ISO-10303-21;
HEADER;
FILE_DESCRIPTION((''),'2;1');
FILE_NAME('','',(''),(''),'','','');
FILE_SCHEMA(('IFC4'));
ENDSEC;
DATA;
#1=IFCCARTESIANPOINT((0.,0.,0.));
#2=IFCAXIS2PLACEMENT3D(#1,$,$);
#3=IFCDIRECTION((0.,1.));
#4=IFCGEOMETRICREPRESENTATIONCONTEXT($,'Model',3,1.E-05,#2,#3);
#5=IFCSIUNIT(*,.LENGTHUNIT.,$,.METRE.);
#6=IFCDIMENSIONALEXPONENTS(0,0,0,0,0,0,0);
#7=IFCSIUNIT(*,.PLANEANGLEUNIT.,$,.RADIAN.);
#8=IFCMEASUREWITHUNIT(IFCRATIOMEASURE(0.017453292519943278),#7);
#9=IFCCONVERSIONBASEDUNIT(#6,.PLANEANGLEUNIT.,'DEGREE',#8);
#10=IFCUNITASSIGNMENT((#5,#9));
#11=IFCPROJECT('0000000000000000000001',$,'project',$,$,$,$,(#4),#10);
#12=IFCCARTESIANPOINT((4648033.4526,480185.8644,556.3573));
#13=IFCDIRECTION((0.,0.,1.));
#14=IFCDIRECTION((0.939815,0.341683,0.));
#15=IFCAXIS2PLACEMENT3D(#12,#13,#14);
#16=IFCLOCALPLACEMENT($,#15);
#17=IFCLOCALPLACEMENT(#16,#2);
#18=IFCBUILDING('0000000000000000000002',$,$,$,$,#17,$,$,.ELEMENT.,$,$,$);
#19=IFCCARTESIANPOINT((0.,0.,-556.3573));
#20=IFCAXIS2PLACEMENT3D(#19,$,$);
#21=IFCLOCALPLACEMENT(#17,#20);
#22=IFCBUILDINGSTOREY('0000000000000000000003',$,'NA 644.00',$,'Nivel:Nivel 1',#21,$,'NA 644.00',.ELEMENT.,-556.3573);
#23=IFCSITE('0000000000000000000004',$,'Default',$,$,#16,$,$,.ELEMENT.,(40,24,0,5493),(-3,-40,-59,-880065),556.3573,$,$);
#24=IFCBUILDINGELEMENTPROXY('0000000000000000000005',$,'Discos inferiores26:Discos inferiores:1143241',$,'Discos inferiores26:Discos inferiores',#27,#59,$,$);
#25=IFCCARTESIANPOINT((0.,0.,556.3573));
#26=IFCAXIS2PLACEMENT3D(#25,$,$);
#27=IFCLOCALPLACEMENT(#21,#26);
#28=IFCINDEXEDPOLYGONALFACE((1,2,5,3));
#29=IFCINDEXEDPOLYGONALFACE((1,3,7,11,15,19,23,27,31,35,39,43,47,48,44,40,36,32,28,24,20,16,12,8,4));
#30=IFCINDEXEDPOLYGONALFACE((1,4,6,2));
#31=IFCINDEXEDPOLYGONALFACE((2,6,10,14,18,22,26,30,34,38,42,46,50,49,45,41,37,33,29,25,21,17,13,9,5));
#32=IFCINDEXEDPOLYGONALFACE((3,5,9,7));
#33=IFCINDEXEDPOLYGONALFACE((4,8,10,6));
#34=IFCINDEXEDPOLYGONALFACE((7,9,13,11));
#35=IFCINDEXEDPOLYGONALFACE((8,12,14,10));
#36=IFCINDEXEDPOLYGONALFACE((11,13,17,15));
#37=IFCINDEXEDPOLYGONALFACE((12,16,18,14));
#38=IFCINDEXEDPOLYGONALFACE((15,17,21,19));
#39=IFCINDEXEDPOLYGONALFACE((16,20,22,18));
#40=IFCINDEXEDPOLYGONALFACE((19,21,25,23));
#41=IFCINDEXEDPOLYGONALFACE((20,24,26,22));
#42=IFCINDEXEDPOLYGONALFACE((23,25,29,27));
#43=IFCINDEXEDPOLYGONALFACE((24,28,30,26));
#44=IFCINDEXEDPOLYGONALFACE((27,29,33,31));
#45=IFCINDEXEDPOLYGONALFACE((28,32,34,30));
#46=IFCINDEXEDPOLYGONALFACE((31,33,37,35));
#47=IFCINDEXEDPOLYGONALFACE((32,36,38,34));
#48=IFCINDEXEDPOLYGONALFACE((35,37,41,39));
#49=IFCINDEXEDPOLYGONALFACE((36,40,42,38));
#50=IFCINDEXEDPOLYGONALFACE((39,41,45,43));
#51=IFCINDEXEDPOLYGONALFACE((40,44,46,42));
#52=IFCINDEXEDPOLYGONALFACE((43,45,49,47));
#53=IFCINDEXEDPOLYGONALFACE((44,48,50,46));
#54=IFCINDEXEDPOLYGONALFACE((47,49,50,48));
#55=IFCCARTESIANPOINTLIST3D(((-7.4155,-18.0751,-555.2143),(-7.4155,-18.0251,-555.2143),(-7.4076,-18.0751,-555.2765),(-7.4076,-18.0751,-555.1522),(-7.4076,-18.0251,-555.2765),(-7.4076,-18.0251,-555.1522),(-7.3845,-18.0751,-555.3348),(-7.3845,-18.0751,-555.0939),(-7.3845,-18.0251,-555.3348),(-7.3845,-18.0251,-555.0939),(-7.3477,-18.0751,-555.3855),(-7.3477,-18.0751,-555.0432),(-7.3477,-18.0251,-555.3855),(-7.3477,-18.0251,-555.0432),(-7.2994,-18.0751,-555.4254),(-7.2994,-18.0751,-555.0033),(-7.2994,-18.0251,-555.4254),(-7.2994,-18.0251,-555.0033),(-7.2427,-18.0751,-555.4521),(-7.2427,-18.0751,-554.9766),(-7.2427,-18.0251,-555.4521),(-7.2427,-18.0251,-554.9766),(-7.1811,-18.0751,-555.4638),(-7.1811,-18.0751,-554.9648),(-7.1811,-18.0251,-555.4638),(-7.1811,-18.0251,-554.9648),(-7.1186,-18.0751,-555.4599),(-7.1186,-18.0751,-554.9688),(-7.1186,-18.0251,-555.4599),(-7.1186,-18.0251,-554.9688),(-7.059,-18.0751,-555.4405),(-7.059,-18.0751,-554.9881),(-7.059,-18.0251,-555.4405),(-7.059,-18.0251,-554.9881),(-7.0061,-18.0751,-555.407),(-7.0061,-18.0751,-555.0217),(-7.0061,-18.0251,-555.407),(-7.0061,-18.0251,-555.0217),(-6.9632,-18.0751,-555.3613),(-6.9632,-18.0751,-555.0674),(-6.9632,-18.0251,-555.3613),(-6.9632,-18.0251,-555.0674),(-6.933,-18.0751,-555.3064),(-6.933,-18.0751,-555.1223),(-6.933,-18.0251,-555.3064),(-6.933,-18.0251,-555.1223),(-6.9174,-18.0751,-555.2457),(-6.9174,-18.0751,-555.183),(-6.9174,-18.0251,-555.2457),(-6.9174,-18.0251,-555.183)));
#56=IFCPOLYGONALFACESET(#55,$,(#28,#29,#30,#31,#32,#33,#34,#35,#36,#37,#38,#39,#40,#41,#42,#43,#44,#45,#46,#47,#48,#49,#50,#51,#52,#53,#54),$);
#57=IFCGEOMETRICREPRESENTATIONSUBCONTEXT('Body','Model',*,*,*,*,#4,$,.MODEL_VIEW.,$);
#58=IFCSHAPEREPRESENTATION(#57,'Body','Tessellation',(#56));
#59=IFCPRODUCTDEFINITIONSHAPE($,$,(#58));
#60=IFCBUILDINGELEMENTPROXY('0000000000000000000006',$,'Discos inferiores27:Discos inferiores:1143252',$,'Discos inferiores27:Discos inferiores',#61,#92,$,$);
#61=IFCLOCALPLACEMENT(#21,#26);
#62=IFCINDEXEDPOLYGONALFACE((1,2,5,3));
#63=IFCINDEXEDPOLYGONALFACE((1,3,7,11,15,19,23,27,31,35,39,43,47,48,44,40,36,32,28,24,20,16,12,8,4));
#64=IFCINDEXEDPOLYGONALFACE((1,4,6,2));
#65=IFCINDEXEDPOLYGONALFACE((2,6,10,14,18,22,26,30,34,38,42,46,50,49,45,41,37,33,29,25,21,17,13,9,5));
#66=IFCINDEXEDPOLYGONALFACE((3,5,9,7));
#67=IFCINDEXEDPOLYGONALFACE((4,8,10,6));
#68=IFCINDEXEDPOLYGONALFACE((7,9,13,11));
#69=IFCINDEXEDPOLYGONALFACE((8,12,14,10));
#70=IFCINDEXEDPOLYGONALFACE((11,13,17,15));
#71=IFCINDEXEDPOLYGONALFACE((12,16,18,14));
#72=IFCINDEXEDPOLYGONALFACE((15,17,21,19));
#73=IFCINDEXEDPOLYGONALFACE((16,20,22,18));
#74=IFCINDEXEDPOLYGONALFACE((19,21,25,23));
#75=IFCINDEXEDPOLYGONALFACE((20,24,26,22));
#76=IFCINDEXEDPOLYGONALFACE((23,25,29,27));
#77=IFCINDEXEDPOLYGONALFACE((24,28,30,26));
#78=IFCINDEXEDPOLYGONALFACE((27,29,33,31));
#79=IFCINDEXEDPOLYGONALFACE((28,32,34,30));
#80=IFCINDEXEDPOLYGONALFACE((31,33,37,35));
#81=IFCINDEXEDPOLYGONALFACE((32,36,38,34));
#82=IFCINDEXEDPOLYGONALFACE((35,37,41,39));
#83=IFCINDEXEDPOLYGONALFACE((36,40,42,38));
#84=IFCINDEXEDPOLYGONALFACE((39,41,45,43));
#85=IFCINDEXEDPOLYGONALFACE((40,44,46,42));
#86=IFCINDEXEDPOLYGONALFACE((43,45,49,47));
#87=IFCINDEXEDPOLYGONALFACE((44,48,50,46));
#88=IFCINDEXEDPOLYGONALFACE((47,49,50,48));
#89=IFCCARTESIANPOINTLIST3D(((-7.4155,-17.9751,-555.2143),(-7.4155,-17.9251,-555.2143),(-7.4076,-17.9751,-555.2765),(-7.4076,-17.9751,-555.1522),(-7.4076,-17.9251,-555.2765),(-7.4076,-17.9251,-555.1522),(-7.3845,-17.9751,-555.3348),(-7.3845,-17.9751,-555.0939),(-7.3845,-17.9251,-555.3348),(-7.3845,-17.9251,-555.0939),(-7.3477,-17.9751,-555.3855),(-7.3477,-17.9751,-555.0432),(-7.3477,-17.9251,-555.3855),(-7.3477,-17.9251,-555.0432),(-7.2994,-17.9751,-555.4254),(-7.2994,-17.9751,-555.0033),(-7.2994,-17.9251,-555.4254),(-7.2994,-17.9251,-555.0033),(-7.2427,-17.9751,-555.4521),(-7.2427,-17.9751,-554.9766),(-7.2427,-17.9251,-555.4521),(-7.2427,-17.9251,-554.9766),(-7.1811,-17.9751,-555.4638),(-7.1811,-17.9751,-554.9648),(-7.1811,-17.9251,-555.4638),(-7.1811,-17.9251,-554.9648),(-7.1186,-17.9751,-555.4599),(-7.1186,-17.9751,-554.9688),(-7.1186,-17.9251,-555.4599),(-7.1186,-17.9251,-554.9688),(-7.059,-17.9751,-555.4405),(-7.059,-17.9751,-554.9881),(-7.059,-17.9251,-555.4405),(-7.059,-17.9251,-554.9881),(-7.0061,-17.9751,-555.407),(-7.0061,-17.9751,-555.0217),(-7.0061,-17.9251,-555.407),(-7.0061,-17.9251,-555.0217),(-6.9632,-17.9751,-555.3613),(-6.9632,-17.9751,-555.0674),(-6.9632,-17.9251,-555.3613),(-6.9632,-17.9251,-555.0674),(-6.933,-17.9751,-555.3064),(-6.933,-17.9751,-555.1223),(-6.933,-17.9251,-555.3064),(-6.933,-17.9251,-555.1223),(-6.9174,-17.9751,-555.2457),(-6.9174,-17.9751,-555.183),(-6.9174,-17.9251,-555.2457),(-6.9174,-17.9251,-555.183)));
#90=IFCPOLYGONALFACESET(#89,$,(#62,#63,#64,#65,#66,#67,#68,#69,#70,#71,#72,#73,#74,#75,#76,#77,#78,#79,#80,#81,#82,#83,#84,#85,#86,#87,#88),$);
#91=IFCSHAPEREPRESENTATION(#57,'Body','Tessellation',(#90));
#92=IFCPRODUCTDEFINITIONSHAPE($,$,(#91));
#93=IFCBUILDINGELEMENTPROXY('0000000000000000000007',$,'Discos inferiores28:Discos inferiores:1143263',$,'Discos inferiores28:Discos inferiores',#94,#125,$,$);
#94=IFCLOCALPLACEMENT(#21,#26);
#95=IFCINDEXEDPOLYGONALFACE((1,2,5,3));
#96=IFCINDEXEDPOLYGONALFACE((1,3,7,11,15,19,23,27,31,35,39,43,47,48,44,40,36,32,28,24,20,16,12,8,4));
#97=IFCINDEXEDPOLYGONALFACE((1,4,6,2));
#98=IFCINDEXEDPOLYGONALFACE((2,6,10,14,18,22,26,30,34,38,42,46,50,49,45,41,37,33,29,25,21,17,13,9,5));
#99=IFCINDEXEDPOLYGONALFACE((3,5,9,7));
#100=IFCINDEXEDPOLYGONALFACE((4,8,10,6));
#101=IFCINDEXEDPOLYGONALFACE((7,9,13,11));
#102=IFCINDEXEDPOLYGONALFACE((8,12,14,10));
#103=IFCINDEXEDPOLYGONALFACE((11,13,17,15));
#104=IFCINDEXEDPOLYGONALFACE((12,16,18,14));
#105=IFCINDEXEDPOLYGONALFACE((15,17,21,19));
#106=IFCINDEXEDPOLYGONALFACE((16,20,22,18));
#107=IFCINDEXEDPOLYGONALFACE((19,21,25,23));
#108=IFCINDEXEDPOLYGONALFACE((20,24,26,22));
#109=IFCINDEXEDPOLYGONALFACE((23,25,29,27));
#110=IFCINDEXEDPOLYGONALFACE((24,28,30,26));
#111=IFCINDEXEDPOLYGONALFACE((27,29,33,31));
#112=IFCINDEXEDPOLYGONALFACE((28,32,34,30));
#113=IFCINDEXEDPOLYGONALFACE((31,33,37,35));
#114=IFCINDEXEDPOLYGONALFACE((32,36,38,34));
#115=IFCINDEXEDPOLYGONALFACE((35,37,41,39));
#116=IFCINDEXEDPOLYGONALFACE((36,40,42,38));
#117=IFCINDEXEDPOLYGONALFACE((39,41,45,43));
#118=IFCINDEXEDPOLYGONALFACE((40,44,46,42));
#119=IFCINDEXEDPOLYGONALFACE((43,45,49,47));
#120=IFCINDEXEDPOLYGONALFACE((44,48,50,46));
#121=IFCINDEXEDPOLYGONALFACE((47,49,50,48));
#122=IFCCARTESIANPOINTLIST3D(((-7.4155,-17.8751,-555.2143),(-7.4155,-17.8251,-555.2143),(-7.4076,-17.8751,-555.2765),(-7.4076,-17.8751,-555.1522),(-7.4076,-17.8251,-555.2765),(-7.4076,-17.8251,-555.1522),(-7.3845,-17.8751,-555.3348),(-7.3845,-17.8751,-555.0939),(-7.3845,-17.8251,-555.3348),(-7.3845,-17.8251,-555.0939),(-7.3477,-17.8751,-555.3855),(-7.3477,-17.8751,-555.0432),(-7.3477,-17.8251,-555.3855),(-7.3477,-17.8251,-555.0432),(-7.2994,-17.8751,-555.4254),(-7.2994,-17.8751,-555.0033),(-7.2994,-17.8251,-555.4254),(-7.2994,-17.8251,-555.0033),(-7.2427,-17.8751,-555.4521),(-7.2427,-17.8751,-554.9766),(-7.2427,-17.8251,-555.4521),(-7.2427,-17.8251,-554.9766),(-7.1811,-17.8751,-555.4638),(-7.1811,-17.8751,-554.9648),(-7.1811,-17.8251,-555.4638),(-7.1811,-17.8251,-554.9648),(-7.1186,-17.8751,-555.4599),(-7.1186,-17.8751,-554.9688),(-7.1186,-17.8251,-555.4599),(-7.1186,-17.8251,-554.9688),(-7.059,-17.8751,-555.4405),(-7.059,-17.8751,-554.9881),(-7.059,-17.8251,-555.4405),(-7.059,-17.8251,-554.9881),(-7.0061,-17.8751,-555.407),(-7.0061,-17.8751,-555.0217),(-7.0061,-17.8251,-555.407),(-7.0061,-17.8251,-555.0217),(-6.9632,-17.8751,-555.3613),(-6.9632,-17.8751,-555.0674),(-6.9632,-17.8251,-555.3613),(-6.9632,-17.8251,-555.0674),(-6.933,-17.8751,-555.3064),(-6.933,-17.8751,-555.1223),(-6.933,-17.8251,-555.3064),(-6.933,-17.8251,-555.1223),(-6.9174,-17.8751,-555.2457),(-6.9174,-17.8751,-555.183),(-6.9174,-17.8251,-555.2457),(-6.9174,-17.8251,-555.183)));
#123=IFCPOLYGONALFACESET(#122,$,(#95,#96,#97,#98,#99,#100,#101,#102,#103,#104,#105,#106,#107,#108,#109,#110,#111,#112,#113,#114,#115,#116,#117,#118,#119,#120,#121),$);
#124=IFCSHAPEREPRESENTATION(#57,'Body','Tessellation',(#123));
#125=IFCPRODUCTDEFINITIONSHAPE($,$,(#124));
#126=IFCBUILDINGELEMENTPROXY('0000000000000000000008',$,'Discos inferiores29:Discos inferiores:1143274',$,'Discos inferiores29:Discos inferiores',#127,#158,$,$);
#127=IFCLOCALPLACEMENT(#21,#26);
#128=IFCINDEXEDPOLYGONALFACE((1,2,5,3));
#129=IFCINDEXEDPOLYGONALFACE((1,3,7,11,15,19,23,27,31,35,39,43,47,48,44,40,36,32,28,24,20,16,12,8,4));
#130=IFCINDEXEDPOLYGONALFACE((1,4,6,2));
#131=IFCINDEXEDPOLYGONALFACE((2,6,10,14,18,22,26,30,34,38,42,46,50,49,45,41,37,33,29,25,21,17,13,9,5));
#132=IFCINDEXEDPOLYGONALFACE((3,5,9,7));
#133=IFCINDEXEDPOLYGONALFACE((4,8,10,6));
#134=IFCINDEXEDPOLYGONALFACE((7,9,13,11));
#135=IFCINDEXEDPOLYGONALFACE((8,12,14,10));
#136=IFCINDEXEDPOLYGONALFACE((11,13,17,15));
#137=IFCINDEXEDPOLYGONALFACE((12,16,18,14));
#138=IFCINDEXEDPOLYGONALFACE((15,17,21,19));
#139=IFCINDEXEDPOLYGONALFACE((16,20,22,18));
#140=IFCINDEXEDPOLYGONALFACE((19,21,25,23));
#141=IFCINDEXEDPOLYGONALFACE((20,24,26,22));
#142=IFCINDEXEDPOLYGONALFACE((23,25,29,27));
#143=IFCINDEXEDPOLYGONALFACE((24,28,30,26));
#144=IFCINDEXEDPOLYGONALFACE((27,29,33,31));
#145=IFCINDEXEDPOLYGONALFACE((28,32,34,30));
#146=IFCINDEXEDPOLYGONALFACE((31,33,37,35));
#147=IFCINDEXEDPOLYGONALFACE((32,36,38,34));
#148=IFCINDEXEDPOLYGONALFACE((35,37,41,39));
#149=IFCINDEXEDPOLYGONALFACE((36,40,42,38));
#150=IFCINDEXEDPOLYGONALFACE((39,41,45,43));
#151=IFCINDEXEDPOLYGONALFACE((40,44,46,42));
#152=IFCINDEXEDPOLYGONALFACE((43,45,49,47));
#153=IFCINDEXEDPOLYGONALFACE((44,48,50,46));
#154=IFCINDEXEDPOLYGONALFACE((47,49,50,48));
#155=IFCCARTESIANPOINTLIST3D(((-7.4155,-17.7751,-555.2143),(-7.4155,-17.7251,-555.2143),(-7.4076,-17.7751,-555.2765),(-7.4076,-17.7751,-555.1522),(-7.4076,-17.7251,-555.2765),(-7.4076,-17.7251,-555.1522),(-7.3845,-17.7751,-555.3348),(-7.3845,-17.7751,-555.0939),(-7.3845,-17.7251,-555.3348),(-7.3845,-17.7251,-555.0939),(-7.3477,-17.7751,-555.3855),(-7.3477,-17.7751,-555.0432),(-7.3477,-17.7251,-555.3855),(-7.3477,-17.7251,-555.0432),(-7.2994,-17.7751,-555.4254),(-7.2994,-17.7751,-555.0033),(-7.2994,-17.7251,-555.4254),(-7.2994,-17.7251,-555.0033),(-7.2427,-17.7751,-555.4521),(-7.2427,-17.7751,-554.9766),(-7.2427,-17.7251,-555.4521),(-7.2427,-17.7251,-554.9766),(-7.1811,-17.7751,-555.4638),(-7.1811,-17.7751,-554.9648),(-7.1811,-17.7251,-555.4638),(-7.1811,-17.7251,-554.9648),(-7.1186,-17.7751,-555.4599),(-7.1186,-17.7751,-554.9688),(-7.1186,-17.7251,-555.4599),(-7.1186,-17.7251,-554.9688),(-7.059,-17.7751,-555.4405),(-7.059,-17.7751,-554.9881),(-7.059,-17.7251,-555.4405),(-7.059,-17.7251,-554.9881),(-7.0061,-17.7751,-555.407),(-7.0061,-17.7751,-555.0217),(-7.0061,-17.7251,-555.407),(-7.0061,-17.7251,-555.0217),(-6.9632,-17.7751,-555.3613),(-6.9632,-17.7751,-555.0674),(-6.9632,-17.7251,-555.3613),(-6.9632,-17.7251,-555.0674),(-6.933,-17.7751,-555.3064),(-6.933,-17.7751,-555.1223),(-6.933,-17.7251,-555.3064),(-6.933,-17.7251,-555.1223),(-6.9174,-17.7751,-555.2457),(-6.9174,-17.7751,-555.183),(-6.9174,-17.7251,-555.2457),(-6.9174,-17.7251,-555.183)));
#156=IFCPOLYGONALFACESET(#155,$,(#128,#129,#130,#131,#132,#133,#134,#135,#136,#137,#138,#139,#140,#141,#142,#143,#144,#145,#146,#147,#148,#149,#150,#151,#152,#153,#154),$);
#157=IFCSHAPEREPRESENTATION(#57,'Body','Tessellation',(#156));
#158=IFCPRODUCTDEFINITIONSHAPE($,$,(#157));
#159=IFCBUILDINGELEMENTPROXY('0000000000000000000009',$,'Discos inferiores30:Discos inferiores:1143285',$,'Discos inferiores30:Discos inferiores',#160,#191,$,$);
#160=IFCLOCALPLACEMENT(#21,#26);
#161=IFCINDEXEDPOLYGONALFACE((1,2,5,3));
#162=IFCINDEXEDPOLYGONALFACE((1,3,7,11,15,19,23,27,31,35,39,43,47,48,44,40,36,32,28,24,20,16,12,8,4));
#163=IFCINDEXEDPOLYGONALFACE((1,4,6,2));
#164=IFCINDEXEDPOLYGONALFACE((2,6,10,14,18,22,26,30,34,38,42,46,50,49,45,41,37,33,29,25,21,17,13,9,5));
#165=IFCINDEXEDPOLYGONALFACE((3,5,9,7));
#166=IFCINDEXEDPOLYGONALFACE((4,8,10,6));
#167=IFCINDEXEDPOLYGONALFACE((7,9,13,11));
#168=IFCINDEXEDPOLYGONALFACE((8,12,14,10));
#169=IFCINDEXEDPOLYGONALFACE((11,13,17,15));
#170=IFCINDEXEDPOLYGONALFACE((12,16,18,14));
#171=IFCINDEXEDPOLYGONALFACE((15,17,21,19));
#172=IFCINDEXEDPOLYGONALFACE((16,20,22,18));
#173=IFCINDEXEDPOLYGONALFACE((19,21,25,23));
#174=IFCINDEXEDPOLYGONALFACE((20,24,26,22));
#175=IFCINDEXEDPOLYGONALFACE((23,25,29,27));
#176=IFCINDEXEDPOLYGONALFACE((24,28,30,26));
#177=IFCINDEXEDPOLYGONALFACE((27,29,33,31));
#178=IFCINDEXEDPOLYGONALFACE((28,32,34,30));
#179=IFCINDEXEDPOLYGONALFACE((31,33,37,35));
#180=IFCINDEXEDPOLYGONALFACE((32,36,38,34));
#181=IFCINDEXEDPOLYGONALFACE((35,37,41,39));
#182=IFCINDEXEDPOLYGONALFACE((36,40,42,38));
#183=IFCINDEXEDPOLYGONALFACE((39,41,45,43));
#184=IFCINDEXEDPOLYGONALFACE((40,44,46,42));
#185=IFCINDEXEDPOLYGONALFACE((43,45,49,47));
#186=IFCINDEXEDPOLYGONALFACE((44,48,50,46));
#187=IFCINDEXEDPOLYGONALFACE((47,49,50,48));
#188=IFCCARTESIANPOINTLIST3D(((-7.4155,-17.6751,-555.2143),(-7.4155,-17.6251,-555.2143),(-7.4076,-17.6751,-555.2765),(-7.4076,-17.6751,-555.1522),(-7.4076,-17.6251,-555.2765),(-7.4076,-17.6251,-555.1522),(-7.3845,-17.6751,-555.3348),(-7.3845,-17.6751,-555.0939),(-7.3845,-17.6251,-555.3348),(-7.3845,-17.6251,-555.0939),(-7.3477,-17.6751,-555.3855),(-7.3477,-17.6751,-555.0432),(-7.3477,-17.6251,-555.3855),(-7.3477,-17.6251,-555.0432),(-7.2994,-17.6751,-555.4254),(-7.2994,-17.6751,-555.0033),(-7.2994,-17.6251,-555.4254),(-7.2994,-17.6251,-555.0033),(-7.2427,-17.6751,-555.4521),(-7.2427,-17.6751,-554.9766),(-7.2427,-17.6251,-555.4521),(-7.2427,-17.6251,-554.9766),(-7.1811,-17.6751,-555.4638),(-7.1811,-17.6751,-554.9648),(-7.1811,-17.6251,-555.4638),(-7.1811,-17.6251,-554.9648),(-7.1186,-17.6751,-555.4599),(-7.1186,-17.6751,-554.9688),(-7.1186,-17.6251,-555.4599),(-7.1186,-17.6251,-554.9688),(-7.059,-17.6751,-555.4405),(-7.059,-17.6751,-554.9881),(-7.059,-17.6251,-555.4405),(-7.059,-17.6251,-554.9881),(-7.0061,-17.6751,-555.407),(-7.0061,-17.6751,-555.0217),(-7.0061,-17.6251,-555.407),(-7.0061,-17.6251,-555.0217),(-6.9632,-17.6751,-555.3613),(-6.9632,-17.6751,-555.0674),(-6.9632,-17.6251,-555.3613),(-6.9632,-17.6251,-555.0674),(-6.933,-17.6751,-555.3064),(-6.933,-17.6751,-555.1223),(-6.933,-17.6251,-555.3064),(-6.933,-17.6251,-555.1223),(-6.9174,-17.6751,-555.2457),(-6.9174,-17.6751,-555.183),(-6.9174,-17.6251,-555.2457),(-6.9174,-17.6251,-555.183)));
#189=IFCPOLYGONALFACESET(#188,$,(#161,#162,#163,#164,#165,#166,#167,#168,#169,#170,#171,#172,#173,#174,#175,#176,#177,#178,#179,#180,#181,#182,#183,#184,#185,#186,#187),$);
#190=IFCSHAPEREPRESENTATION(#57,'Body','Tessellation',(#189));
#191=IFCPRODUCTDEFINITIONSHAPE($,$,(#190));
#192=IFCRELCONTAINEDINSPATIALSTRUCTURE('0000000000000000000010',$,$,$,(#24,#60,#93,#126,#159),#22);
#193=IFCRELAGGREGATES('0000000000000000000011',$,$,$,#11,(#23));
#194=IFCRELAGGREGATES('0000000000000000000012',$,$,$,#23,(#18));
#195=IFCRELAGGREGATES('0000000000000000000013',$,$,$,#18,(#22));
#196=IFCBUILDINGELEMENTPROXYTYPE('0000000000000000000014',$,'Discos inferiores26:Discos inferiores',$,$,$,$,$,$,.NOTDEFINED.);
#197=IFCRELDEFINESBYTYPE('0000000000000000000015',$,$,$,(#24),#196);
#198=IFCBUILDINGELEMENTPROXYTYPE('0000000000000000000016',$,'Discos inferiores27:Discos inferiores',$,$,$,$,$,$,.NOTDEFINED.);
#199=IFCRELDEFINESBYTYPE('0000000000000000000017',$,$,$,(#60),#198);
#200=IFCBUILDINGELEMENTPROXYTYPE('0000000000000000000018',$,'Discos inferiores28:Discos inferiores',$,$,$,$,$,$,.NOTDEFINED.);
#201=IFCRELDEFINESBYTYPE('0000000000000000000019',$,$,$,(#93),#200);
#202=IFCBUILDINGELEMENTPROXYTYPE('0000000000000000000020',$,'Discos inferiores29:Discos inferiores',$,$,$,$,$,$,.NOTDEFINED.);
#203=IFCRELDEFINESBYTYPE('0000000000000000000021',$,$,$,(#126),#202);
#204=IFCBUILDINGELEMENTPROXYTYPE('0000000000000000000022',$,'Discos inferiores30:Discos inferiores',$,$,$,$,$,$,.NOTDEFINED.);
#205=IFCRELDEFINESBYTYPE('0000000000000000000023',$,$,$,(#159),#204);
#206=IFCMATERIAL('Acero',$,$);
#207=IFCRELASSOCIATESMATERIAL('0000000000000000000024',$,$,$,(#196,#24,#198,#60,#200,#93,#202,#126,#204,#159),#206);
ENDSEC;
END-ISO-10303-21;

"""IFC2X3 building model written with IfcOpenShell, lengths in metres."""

from ifc_helpers import new_model, entity, si_unit, converted_unit, direction, frame, origin, origin_2d_with_axis, place, context, subcontext, project, spatial, circle, extrude, source, transform, mapped, material, type_object, type_shapes, element, save


model = new_model("IFC2X3")

# Units and contexts
model_context = context("Model", 3, precision=1e-05, world=origin(), true_north=direction((0.0, 1.0)))
body_context = subcontext(model_context, "Body", "Model", "MODEL_VIEW")
ifc_project = project(units=[si_unit("LENGTHUNIT", "METRE"), converted_unit("PLANEANGLEUNIT", "DEGREE", entity("IfcRatioMeasure", 0.017453292519943278), si_unit("PLANEANGLEUNIT", "RADIAN"), dimensions=[0, 0, 0, 0, 0, 0, 0])], contexts=[model_context])

# Site, building, storey
site_placement = place(None, frame((4648033.4526, 480185.8644, 556.3573), z_axis=(0.0, 0.0, 1.0), x_axis=(0.939815, 0.341683, 0.0)))
site = spatial("IfcSite", under=ifc_project, at=site_placement, Name="Default", CompositionType="ELEMENT", RefLatitude=(40, 24, 0, 5493), RefLongitude=(-3, -40, -59, -880065), RefElevation=556.3573)
building_placement = place(site_placement, origin())
building = spatial("IfcBuilding", under=site, at=building_placement, CompositionType="ELEMENT")
storey_placement = place(building_placement, frame((0.0, 0.0, -556.3573)))
storey = spatial("IfcBuildingStorey", under=building, at=storey_placement, Name="NA 644.00", ObjectType="Nivel:Nivel 1", LongName="NA 644.00", CompositionType="ELEMENT", Elevation=-556.3573)

# Building element proxies
ifc_material_1 = material(Name="Acero")
building_element_proxy_type_1 = type_object("IfcBuildingElementProxyType", Name="Discos inferiores26:Discos inferiores", PredefinedType="NOTDEFINED", material=ifc_material_1)
shared_shape_1 = source(origin(), body_context, "Body", "SweptSolid", [
    extrude(circle(Radius=0.25, at=origin_2d_with_axis()), frame((-7.1655, -18.0751, -555.2143), z_axis=(0.0, 1.0, 0.0), x_axis=(-1.0, 0.0, 0.0)), (0.0, 0.0, 1.0), 0.05),
])
type_shapes(building_element_proxy_type_1, [shared_shape_1])
proxy_1_placement = place(storey_placement, frame((0.0, 0.0, 556.3573)))
element("IfcBuildingElementProxy", 1, at=proxy_1_placement, inside=storey, type_object=building_element_proxy_type_1, material=ifc_material_1, Name="Discos inferiores26:Discos inferiores:1143241", ObjectType="Discos inferiores26:Discos inferiores", context=body_context, shape_type="MappedRepresentation", body=[
    mapped(shared_shape_1, transform((0.0, 0.0, 0.0), scale=1.0)),
])
building_element_proxy_type_2 = type_object("IfcBuildingElementProxyType", Name="Discos inferiores27:Discos inferiores", PredefinedType="NOTDEFINED", material=ifc_material_1)
shared_shape_2 = source(origin(), body_context, "Body", "SweptSolid", [
    extrude(circle(Radius=0.25, at=origin_2d_with_axis()), frame((-7.1655, -17.9751, -555.2143), z_axis=(0.0, 1.0, 0.0), x_axis=(-1.0, 0.0, 0.0)), (0.0, 0.0, 1.0), 0.05),
])
type_shapes(building_element_proxy_type_2, [shared_shape_2])
proxy_2_placement = place(storey_placement, frame((0.0, 0.0, 556.3573)))
element("IfcBuildingElementProxy", 2, at=proxy_2_placement, inside=storey, type_object=building_element_proxy_type_2, material=ifc_material_1, Name="Discos inferiores27:Discos inferiores:1143252", ObjectType="Discos inferiores27:Discos inferiores", context=body_context, shape_type="MappedRepresentation", body=[
    mapped(shared_shape_2, transform((0.0, 0.0, 0.0), scale=1.0)),
])
building_element_proxy_type_3 = type_object("IfcBuildingElementProxyType", Name="Discos inferiores28:Discos inferiores", PredefinedType="NOTDEFINED", material=ifc_material_1)
shared_shape_3 = source(origin(), body_context, "Body", "SweptSolid", [
    extrude(circle(Radius=0.25, at=origin_2d_with_axis()), frame((-7.1655, -17.8751, -555.2143), z_axis=(0.0, 1.0, 0.0), x_axis=(-1.0, 0.0, 0.0)), (0.0, 0.0, 1.0), 0.05),
])
type_shapes(building_element_proxy_type_3, [shared_shape_3])
proxy_3_placement = place(storey_placement, frame((0.0, 0.0, 556.3573)))
element("IfcBuildingElementProxy", 3, at=proxy_3_placement, inside=storey, type_object=building_element_proxy_type_3, material=ifc_material_1, Name="Discos inferiores28:Discos inferiores:1143263", ObjectType="Discos inferiores28:Discos inferiores", context=body_context, shape_type="MappedRepresentation", body=[
    mapped(shared_shape_3, transform((0.0, 0.0, 0.0), scale=1.0)),
])
building_element_proxy_type_4 = type_object("IfcBuildingElementProxyType", Name="Discos inferiores29:Discos inferiores", PredefinedType="NOTDEFINED", material=ifc_material_1)
shared_shape_4 = source(origin(), body_context, "Body", "SweptSolid", [
    extrude(circle(Radius=0.25, at=origin_2d_with_axis()), frame((-7.1655, -17.7751, -555.2143), z_axis=(0.0, 1.0, 0.0), x_axis=(-1.0, 0.0, 0.0)), (0.0, 0.0, 1.0), 0.05),
])
type_shapes(building_element_proxy_type_4, [shared_shape_4])
proxy_4_placement = place(storey_placement, frame((0.0, 0.0, 556.3573)))
element("IfcBuildingElementProxy", 4, at=proxy_4_placement, inside=storey, type_object=building_element_proxy_type_4, material=ifc_material_1, Name="Discos inferiores29:Discos inferiores:1143274", ObjectType="Discos inferiores29:Discos inferiores", context=body_context, shape_type="MappedRepresentation", body=[
    mapped(shared_shape_4, transform((0.0, 0.0, 0.0), scale=1.0)),
])
building_element_proxy_type_5 = type_object("IfcBuildingElementProxyType", Name="Discos inferiores30:Discos inferiores", PredefinedType="NOTDEFINED", material=ifc_material_1)
shared_shape_5 = source(origin(), body_context, "Body", "SweptSolid", [
    extrude(circle(Radius=0.25, at=origin_2d_with_axis()), frame((-7.1655, -17.6751, -555.2143), z_axis=(0.0, 1.0, 0.0), x_axis=(-1.0, 0.0, 0.0)), (0.0, 0.0, 1.0), 0.05),
])
type_shapes(building_element_proxy_type_5, [shared_shape_5])
proxy_5_placement = place(storey_placement, frame((0.0, 0.0, 556.3573)))
element("IfcBuildingElementProxy", 5, at=proxy_5_placement, inside=storey, type_object=building_element_proxy_type_5, material=ifc_material_1, Name="Discos inferiores30:Discos inferiores:1143285", ObjectType="Discos inferiores30:Discos inferiores", context=body_context, shape_type="MappedRepresentation", body=[
    mapped(shared_shape_5, transform((0.0, 0.0, 0.0), scale=1.0)),
])

save(model, "model.ifc")
